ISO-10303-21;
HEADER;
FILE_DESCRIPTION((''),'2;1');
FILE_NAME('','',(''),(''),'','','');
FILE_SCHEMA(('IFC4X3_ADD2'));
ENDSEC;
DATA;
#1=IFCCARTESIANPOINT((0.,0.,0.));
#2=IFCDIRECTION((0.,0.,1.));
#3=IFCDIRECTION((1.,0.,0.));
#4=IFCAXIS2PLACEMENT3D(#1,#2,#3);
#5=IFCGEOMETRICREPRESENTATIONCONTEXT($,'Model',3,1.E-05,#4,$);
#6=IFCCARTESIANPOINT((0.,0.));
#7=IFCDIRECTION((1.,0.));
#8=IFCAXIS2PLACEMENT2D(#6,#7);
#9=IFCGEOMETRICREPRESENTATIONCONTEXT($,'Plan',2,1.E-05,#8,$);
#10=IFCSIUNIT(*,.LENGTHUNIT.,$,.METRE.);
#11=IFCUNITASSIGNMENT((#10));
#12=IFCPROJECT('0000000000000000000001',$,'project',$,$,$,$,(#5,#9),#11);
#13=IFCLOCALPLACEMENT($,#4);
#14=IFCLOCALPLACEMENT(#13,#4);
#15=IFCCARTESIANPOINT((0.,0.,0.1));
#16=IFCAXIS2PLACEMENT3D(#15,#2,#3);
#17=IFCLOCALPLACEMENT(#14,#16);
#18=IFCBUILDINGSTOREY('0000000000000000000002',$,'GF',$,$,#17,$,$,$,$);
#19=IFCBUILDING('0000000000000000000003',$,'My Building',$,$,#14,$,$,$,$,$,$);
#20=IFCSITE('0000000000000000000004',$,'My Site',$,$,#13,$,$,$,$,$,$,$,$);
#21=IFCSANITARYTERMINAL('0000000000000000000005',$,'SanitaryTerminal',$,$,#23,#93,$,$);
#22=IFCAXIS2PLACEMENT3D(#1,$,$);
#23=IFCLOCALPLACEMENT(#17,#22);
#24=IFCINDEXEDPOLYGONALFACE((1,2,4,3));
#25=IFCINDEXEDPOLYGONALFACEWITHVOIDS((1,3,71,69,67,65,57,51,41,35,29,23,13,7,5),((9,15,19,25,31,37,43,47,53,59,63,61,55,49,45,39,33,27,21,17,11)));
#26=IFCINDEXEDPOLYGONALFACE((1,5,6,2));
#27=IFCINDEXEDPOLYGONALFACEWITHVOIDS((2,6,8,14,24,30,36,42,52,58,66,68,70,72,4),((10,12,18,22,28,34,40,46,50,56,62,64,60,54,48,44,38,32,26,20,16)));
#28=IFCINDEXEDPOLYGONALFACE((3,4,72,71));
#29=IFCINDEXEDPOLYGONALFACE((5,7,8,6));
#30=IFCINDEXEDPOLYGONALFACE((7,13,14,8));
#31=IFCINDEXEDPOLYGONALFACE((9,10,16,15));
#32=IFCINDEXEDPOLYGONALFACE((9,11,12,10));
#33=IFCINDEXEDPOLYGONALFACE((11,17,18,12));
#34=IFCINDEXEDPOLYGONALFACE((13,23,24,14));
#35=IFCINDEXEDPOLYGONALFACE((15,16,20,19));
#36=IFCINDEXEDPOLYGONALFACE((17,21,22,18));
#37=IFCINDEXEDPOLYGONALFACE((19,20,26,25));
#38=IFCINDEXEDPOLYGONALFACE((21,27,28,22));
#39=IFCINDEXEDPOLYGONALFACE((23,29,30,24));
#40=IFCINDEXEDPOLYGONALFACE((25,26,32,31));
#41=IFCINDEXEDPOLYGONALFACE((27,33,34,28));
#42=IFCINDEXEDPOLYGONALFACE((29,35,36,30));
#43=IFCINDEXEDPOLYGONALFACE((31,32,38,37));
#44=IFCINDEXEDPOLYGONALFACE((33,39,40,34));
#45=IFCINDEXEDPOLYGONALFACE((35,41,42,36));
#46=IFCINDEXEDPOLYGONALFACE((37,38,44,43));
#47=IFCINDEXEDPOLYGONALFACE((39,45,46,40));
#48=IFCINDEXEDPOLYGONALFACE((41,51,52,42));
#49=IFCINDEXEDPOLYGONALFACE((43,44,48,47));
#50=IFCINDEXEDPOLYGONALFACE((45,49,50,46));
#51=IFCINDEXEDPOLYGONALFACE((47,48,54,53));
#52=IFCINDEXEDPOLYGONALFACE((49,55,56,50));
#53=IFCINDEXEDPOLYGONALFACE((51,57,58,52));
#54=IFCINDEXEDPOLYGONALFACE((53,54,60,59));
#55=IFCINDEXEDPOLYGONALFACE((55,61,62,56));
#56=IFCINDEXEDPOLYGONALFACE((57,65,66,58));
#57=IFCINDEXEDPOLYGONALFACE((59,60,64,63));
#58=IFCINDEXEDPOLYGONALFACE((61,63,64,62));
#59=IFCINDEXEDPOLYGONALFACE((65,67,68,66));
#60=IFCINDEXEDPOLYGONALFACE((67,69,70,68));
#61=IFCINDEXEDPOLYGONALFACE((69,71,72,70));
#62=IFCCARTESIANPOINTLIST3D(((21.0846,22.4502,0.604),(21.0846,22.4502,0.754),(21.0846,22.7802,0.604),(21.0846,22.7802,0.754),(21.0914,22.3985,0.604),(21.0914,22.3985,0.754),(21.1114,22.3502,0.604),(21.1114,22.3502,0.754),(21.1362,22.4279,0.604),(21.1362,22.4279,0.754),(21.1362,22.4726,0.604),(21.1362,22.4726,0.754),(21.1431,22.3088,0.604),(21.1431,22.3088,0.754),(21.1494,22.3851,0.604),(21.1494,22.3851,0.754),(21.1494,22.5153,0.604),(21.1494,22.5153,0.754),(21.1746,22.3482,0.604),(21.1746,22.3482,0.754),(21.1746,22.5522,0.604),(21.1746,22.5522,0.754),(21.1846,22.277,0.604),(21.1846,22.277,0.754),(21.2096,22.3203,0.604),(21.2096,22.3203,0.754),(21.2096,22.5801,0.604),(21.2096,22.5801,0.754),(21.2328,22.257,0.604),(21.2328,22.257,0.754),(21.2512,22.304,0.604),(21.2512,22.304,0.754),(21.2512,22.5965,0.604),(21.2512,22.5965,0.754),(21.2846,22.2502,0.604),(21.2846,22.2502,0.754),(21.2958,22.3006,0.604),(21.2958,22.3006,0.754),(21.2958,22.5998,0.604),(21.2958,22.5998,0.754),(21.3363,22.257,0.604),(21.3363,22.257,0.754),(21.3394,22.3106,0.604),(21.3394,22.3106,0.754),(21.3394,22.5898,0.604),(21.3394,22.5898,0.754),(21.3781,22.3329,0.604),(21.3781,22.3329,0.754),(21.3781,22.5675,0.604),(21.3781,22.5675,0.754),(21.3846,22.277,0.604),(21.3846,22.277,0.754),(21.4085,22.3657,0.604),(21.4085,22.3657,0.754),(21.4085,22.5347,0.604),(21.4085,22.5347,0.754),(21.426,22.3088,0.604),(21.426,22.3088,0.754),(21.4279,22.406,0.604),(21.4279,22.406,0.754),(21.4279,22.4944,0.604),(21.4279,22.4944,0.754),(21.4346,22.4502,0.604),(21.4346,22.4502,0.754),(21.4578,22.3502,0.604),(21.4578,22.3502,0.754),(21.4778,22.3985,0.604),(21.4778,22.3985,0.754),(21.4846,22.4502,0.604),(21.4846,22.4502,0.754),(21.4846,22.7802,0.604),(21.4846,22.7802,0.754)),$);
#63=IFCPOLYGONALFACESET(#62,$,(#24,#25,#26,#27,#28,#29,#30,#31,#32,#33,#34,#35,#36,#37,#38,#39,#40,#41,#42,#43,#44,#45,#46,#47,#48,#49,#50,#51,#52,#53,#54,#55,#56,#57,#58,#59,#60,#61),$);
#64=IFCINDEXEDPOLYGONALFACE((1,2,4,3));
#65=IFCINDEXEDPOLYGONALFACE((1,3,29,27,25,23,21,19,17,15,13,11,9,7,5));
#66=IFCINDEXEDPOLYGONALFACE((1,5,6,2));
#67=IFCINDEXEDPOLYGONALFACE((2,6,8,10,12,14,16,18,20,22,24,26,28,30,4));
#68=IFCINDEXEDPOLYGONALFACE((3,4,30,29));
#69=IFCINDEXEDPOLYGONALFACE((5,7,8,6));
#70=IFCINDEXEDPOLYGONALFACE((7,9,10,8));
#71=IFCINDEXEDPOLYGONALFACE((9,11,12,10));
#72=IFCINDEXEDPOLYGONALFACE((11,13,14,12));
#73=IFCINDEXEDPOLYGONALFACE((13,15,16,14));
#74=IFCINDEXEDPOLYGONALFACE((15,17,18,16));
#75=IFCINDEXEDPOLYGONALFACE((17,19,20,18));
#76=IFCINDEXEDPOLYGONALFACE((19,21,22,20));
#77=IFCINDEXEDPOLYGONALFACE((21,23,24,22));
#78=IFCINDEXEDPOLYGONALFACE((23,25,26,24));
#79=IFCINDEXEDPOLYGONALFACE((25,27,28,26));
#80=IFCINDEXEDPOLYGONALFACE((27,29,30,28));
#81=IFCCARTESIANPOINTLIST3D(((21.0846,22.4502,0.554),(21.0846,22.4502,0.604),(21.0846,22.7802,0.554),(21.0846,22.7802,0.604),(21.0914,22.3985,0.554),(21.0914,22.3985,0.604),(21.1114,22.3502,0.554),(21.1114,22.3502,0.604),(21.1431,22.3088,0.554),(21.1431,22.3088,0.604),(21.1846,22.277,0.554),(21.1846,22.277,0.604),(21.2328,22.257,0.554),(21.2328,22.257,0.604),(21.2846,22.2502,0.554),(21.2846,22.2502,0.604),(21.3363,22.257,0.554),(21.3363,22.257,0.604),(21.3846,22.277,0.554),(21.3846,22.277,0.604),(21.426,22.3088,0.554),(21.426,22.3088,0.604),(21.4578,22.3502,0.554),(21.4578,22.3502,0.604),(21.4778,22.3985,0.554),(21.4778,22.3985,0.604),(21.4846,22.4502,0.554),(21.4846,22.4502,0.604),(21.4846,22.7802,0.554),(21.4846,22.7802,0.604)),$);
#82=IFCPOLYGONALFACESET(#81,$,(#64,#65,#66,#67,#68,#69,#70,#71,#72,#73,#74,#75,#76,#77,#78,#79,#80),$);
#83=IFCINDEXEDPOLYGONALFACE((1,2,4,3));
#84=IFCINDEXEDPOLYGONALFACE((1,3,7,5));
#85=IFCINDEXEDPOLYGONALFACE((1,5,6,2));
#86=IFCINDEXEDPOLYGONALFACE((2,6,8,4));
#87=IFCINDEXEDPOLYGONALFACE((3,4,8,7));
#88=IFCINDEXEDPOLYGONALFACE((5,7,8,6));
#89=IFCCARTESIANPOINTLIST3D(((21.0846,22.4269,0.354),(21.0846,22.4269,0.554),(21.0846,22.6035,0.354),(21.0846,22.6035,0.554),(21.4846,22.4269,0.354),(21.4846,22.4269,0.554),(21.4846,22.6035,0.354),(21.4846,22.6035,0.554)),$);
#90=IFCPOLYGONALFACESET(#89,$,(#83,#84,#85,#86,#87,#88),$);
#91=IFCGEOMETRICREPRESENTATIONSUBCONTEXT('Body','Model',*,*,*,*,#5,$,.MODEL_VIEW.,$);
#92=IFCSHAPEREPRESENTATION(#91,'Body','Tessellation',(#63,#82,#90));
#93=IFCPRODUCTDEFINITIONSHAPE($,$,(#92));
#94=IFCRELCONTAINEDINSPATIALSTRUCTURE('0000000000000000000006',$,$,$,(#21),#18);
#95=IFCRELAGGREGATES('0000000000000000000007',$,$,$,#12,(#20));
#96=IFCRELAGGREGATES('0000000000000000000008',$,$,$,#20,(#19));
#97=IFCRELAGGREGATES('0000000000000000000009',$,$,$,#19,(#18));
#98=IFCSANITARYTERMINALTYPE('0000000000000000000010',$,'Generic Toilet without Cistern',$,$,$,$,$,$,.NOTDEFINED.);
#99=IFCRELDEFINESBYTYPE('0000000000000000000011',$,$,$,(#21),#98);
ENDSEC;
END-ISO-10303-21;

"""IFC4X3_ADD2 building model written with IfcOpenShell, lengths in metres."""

from ifc_helpers import new_model, entity, si_unit, frame, frame_2d, origin_with_axes, origin_2d_with_axis, place, context, subcontext, project, spatial, line, arc, indexed_curve, circle_curve, outline, extrude, shape, source, transform, mapped, type_object, type_shapes, element, save


model = new_model("IFC4X3_ADD2")

# Units and contexts
model_context = context("Model", 3, precision=1e-05, world=origin_with_axes())
plan_context = context("Plan", 2, precision=1e-05, world=origin_2d_with_axis())
body_context_1 = subcontext(model_context, "Body", "Model", "MODEL_VIEW")
body_context_2 = subcontext(plan_context, "Body", "Plan", "PLAN_VIEW")
ifc_project = project(units=[si_unit("LENGTHUNIT", "METRE")], contexts=[model_context, plan_context])

# Site, building, storey
site_placement = place(None, origin_with_axes())
site = spatial("IfcSite", under=ifc_project, at=site_placement, Name="My Site")
building_placement = place(site_placement, origin_with_axes())
building = spatial("IfcBuilding", under=site, at=building_placement, Name="My Building")
storey_placement = place(building_placement, frame((0.0, 0.0, 0.1), z_axis=(0.0, 0.0, 1.0), x_axis=(1.0, 0.0, 0.0)))
storey = spatial("IfcBuildingStorey", under=building, at=storey_placement, Name="GF")

# Sanitary terminal
sanitary_terminal_type_1 = type_object("IfcSanitaryTerminalType", Name="Generic Toilet without Cistern", PredefinedType="NOTDEFINED")
shared_shape_1 = source(origin_with_axes(), body_context_1, "Body", "SweptSolid", [
    extrude(outline(indexed_curve([(-0.2, 0.0), (0.2, 0.0), (0.2, -0.33), (0.1414, -0.4714), (0.0, -0.53), (-0.1414, -0.4714), (-0.2, -0.33)], segments=[line(1, 2), line(2, 3), arc(3, 4, 5), arc(5, 6, 7), line(7, 1)]), holes=[circle_curve(frame_2d((0.0, -0.33)), 0.15)]), frame((0.0, 0.0, 0.25), z_axis=(0.0, 0.0, 1.0), x_axis=(1.0, 0.0, 0.0)), (0.0, 0.0, 1.0), 0.15),
    extrude(outline(indexed_curve([(-0.2, 0.0), (0.2, 0.0), (0.2, -0.33), (0.1414, -0.4714), (0.0, -0.53), (-0.1414, -0.4714), (-0.2, -0.33)], segments=[line(1, 2), line(2, 3), arc(3, 4, 5), arc(5, 6, 7), line(7, 1)])), frame((0.0, 0.0, 0.2), z_axis=(0.0, 0.0, 1.0), x_axis=(1.0, 0.0, 0.0)), (0.0, 0.0, 1.0), 0.05),
    extrude(outline(indexed_curve([(-0.2, -0.1767), (0.2, -0.1767), (0.2, -0.3533), (-0.2, -0.3533)], segments=[line(1, 2, 3, 4, 1)])), origin_with_axes(), (0.0, 0.0, 1.0), 0.2),
])
shared_shape_2 = source(origin_with_axes(), body_context_2, "Body", "GeometricSet", [
    entity("IfcGeometricCurveSet", [entity("IfcIndexedPolyCurve", entity("IfcCartesianPointList2D", [[-0.1068, -0.124], [-0.0957, -0.1129], [-0.0804, -0.1088], [0.0804, -0.1088], [0.0957, -0.1129], [0.1068, -0.124], [0.1109, -0.1393], [0.1109, -0.3476], [0.1025, -0.3926], [0.0784, -0.4308], [0.0424, -0.4563], [0.0, -0.4652], [-0.0424, -0.4563], [-0.0784, -0.4308], [-0.1025, -0.3926], [-0.1109, -0.3476], [-0.1109, -0.1393]]), [entity("IfcLineIndex", [1, 2, 3, 4, 5, 6, 7, 8, 9, 10, 11, 12, 13, 14, 15, 16, 17, 1])]), entity("IfcIndexedPolyCurve", entity("IfcCartesianPointList2D", [[-0.1962, -0.2314], [-0.1848, -0.301], [-0.1764, -0.3339], [-0.1663, -0.3651], [-0.1546, -0.3944], [-0.1414, -0.4213], [-0.1269, -0.4458], [-0.1111, -0.4675], [-0.0943, -0.4862], [-0.0765, -0.5018], [-0.0581, -0.514], [-0.039, -0.5229], [-0.0196, -0.5282], [0.0, -0.53], [0.0196, -0.5282], [0.039, -0.5229], [0.0581, -0.514], [0.0765, -0.5018], [0.0943, -0.4862], [0.1111, -0.4675], [0.1269, -0.4458], [0.1414, -0.4213], [0.1546, -0.3944], [0.1663, -0.3651], [0.1764, -0.3339], [0.1848, -0.301], [0.1962, -0.2314], [0.2, -0.159], [0.1872, 0.0], [-0.1872, 0.0], [-0.2, -0.159]]), [entity("IfcLineIndex", [1, 2, 3, 4, 5, 6, 7, 8, 9, 10, 11, 12, 13, 14, 15, 16, 17, 18, 19, 20, 21, 22, 23, 24, 25, 26, 27, 28, 29, 30, 31, 1])])]),
])
type_shapes(sanitary_terminal_type_1, [shared_shape_1, shared_shape_2])
sanitary_terminal_1_placement = place(storey_placement, frame((21.2846, 22.7802, 0.354), z_axis=(0.0, 0.0, 1.0), x_axis=(1.0, 0.0, 0.0)))
element("IfcSanitaryTerminal", 1, at=sanitary_terminal_1_placement, inside=storey, type_object=sanitary_terminal_type_1, Name="SanitaryTerminal", shapes=[
    shape(body_context_1, "Body", "MappedRepresentation", [mapped(shared_shape_1, transform((0.0, 0.0, 0.0), x_axis=(1.0, 0.0, 0.0), y_axis=(0.0, 1.0, 0.0), z_axis=(0.0, 0.0, 1.0), scale=1.0))]),
    shape(body_context_2, "Body", "MappedRepresentation", [mapped(shared_shape_2, transform((0.0, 0.0, 0.0), x_axis=(1.0, 0.0, 0.0), y_axis=(0.0, 1.0, 0.0), z_axis=(0.0, 0.0, 1.0), scale=1.0))]),
])

save(model, "model.ifc")
